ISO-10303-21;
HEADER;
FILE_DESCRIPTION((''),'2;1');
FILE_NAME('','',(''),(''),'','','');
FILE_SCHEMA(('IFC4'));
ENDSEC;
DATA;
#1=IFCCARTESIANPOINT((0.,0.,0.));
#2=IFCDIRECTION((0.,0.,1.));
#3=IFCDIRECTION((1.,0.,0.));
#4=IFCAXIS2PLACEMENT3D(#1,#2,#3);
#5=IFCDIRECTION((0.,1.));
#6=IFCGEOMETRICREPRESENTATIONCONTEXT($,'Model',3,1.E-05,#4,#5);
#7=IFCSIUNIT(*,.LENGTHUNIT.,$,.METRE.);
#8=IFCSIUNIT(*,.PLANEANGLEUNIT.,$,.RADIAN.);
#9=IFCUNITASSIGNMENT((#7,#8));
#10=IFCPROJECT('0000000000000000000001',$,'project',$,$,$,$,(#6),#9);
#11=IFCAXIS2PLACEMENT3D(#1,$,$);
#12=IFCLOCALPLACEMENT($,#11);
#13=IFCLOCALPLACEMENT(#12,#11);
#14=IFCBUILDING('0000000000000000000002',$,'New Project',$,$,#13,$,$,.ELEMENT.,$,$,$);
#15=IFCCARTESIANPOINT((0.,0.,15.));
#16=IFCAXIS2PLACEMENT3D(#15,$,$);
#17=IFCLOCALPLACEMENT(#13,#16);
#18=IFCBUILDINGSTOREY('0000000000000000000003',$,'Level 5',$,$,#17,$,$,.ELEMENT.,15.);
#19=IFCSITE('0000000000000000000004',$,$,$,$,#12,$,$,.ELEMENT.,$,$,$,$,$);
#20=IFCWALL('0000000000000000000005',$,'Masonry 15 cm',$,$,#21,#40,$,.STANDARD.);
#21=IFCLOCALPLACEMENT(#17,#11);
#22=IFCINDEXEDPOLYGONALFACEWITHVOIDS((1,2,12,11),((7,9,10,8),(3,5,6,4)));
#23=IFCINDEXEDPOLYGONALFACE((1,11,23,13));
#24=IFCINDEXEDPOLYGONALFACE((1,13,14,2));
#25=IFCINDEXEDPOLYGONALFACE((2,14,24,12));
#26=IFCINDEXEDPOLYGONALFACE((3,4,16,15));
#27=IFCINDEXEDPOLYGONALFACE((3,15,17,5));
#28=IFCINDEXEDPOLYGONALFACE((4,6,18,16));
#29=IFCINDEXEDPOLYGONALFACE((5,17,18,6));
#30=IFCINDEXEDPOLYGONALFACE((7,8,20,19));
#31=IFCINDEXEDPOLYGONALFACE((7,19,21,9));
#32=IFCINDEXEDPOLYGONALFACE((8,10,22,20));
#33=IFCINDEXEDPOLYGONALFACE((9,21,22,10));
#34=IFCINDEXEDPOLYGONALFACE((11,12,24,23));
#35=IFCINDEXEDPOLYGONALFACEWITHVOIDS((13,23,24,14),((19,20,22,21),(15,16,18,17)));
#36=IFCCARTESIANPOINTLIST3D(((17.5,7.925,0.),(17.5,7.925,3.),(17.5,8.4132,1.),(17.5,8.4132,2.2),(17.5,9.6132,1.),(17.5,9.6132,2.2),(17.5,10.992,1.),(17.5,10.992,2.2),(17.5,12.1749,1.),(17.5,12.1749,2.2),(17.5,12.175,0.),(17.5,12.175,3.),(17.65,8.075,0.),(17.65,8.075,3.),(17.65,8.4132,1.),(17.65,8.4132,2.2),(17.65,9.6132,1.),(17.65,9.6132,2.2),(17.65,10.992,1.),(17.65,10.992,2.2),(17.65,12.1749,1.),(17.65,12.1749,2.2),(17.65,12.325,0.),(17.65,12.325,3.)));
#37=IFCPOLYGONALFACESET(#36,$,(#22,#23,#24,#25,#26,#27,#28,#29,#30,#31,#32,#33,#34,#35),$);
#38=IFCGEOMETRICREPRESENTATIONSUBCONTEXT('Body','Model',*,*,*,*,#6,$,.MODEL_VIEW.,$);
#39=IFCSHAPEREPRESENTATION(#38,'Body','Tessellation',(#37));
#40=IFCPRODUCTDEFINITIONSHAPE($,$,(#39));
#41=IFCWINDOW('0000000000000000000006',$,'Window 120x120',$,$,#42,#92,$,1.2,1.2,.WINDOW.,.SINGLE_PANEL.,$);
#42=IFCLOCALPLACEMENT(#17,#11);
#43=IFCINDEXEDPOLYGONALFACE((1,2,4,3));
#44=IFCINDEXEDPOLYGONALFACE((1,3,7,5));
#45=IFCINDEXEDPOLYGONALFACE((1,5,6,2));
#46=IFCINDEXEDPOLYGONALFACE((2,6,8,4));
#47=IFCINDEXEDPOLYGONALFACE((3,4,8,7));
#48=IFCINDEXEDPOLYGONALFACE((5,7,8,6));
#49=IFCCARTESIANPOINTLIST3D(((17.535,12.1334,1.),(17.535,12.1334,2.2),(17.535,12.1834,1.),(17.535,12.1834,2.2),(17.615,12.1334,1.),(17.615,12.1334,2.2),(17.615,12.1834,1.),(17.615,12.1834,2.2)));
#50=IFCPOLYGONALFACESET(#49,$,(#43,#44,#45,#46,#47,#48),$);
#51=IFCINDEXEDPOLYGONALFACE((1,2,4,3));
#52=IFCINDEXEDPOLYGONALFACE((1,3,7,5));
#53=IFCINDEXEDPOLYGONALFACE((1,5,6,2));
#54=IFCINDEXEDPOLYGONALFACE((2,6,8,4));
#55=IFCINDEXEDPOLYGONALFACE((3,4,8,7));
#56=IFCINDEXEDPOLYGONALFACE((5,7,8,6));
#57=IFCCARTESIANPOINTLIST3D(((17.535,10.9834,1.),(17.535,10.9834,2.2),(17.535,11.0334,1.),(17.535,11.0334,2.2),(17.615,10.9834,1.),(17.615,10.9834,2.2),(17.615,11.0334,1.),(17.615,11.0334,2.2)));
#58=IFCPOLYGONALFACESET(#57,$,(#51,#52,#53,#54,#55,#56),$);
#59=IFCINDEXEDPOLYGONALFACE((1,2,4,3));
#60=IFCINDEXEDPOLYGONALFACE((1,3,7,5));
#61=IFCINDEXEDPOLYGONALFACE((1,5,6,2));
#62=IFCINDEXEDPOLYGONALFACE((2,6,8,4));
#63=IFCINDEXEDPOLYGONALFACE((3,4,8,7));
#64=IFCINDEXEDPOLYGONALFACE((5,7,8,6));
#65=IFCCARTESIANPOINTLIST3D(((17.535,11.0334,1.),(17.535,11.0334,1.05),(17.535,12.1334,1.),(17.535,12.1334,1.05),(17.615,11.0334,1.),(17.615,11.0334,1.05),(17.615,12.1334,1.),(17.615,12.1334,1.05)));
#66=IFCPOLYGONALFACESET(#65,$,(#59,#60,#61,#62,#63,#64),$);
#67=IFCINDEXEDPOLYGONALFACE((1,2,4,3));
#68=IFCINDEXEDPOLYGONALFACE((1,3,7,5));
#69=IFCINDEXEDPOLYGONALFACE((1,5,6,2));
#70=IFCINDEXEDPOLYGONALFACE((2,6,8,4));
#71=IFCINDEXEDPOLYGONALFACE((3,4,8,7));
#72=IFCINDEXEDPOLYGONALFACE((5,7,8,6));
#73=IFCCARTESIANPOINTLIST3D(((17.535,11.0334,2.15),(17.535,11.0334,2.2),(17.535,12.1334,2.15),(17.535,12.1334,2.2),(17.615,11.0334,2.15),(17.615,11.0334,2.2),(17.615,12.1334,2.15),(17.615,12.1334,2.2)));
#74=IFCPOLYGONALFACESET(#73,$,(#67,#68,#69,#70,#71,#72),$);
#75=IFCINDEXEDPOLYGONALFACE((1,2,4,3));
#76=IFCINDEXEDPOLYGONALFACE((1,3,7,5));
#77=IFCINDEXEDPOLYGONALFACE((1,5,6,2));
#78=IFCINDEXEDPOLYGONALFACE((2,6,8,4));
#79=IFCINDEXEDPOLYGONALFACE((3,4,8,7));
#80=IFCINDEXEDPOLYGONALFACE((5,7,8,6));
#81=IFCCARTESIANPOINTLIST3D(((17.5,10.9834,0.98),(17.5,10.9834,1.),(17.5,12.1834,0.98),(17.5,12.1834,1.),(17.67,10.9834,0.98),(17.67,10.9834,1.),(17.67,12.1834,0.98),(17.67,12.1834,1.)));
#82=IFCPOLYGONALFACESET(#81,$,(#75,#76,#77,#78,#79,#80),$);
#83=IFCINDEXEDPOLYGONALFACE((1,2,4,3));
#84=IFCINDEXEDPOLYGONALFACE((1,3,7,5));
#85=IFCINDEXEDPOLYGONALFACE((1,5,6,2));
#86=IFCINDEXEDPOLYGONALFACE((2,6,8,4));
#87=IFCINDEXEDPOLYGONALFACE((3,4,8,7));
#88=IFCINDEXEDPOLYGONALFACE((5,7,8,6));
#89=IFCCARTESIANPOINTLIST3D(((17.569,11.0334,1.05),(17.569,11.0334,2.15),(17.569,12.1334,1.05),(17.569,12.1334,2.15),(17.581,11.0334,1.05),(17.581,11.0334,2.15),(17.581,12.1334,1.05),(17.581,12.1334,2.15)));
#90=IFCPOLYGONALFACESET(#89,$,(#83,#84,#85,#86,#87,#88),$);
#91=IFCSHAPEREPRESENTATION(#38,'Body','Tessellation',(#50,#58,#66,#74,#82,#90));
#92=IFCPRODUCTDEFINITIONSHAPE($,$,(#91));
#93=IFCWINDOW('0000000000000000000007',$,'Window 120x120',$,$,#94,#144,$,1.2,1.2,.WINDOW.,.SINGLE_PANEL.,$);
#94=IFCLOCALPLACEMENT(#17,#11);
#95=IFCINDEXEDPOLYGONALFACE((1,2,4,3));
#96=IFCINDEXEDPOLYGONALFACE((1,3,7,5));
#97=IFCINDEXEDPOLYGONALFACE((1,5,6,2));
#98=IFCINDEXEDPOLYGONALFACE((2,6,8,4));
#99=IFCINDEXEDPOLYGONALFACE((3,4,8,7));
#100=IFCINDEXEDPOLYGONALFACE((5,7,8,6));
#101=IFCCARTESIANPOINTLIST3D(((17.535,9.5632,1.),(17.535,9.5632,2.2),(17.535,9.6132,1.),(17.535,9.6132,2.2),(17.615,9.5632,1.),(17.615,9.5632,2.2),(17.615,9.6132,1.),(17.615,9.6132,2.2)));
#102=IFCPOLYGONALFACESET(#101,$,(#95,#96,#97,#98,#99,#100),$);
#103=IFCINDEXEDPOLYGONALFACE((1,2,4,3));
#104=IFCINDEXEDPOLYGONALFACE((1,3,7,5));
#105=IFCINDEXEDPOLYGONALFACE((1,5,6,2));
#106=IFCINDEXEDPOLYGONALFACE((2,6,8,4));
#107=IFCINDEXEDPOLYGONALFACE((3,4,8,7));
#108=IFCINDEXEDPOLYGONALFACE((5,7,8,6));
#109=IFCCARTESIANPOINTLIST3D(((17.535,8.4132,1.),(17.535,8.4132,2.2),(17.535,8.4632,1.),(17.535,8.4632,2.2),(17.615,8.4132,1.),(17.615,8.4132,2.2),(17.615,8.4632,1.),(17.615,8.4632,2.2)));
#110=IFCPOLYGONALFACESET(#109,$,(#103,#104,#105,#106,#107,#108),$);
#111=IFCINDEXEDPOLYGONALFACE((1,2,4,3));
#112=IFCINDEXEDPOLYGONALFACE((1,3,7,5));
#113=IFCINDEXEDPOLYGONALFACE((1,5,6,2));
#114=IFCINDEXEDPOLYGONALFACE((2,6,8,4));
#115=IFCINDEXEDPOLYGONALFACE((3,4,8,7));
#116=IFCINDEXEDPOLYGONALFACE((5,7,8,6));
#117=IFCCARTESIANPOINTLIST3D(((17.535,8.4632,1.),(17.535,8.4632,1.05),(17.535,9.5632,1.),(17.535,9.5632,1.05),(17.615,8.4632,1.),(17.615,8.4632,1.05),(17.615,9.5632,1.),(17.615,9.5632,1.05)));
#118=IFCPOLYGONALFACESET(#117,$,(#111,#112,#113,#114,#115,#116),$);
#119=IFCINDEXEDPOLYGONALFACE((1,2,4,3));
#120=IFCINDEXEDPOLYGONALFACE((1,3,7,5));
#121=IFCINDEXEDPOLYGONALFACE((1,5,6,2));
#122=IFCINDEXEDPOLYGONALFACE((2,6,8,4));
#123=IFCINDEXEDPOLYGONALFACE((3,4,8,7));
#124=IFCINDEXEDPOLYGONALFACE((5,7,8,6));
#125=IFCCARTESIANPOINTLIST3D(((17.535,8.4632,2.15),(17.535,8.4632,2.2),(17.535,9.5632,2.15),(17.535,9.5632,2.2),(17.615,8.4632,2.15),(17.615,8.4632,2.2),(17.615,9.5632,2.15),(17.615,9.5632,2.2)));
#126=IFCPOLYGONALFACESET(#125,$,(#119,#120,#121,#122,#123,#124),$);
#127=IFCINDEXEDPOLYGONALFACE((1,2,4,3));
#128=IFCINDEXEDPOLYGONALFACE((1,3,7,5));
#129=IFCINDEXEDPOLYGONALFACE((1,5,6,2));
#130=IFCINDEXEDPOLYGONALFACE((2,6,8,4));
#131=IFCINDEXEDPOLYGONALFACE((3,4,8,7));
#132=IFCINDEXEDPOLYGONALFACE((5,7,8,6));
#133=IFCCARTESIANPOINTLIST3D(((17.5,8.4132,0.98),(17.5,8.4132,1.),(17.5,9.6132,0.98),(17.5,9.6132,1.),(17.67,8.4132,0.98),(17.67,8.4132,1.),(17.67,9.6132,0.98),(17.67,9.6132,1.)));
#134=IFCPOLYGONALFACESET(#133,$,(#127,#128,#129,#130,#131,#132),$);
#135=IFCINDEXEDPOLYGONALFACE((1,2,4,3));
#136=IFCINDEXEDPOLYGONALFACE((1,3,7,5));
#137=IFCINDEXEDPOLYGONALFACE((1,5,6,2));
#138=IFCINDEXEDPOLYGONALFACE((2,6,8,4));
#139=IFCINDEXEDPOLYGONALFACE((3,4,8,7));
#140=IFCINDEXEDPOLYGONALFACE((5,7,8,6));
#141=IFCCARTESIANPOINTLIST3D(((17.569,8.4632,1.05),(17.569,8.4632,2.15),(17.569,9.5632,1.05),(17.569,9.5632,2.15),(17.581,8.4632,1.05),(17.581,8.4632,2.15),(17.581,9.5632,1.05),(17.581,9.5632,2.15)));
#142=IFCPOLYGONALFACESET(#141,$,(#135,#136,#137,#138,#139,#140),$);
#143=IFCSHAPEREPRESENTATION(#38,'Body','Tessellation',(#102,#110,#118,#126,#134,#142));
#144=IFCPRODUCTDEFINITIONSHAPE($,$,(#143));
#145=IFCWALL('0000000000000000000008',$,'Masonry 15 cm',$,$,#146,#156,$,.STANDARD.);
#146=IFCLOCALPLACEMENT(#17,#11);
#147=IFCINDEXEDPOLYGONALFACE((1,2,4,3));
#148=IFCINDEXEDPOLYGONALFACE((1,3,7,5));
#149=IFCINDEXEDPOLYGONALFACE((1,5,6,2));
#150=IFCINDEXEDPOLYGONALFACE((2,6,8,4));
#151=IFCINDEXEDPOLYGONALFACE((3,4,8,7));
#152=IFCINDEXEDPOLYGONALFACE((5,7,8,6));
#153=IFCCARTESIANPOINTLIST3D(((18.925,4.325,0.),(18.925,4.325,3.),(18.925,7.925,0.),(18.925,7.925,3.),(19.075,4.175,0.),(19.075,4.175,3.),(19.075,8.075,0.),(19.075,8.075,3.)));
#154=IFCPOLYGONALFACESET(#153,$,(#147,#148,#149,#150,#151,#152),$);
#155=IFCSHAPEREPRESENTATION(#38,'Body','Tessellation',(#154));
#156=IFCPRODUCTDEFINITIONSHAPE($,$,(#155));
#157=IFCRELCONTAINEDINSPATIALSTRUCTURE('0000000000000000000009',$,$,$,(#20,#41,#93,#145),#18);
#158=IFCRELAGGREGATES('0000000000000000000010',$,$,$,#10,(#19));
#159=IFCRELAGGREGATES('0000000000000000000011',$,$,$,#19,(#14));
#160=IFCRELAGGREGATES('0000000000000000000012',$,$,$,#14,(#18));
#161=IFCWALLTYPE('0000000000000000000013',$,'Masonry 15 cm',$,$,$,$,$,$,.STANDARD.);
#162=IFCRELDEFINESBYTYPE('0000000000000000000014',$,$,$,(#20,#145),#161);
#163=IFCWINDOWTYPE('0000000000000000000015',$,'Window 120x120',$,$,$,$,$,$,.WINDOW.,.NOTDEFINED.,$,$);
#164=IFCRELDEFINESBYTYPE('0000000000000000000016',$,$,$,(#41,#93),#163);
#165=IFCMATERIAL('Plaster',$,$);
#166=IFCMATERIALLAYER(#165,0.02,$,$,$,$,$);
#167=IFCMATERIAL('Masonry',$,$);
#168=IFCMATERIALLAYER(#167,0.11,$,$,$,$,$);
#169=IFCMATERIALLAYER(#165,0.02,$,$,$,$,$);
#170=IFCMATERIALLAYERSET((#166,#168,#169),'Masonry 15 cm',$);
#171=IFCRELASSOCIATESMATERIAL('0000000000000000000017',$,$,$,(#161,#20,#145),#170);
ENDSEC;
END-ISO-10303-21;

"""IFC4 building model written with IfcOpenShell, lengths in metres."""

from ifc_helpers import new_model, si_unit, direction, frame, frame_2d, origin, origin_with_axes, place, context, subcontext, project, spatial, polyline, rectangle, outline, extrude, material, layer, layer_set, layer_usage, type_object, element, fill, save


model = new_model("IFC4")

# Units and contexts
model_context = context("Model", 3, precision=1e-05, world=origin_with_axes(), true_north=direction((0.0, 1.0)))
body_context = subcontext(model_context, "Body", "Model", "MODEL_VIEW")
ifc_project = project(units=[si_unit("LENGTHUNIT", "METRE"), si_unit("PLANEANGLEUNIT", "RADIAN")], contexts=[model_context])

# Site, building, storey
site_placement = place(None, origin())
site = spatial("IfcSite", under=ifc_project, at=site_placement, CompositionType="ELEMENT")
building_placement = place(site_placement, origin())
building = spatial("IfcBuilding", under=site, at=building_placement, Name="New Project", CompositionType="ELEMENT")
storey_placement = place(building_placement, frame((0.0, 0.0, 15.0)))
storey = spatial("IfcBuildingStorey", under=building, at=storey_placement, Name="Level 5", CompositionType="ELEMENT", Elevation=15.0)

# Shared definitions
ifc_material_1 = material(Name="Plaster")
ifc_layer_1 = layer(ifc_material_1, 0.02)
ifc_material_2 = material(Name="Masonry")
ifc_layer_2 = layer(ifc_material_2, 0.11)
ifc_layer_3 = layer(ifc_material_1, 0.02)
ifc_layer_set_1 = layer_set([ifc_layer_1, ifc_layer_2, ifc_layer_3], Name="Masonry 15 cm")
ifc_layer_usage_1 = layer_usage(ifc_layer_set_1, "AXIS2", "NEGATIVE", 0.075)
wall_type_1 = type_object("IfcWallType", Name="Masonry 15 cm", PredefinedType="STANDARD", material=ifc_layer_set_1)
window_type = type_object("IfcWindowType", Name="Window 120x120", PartitioningType="NOTDEFINED", PredefinedType="WINDOW")

# Wall, openings, windows
wall_1_placement = place(storey_placement, frame((17.575, 12.25, 0.0), z_axis=(0.0, 0.0, 1.0), x_axis=(0.0, -1.0, 0.0)))
wall_1 = element("IfcWall", 1, at=wall_1_placement, inside=storey, type_object=wall_type_1, material=ifc_layer_usage_1, Name="Masonry 15 cm", PredefinedType="STANDARD", context=body_context, shape_type="SweptSolid", body=[
    extrude(outline(polyline([(0.075, -0.075), (4.325, -0.075), (4.175, 0.075), (-0.075, 0.075), (0.075, -0.075)])), origin(), (0.0, 0.0, 1.0), 3.0),
])
opening_1_placement = place(wall_1_placement, frame((0.0751, 0.0, 1.0)))
opening_1 = element("IfcOpeningElement", 2, at=opening_1_placement, cuts=wall_1, PredefinedType="OPENING", context=body_context, shape_type="SweptSolid", body=[
    extrude(rectangle(XDim=1.1829, YDim=0.25, at=frame_2d((0.5915, 0.0))), origin(), (0.0, 0.0, 1.0), 1.2),
])
opening_2_placement = place(wall_1_placement, frame((2.6368, 0.0, 1.0)))
opening_2 = element("IfcOpeningElement", 3, at=opening_2_placement, cuts=wall_1, PredefinedType="OPENING", context=body_context, shape_type="SweptSolid", body=[
    extrude(rectangle(XDim=1.2, YDim=0.25, at=frame_2d((0.6, 0.0))), origin(), (0.0, 0.0, 1.0), 1.2),
])
window_1_placement = place(opening_1_placement, origin())
window_1 = element("IfcWindow", 4, at=window_1_placement, inside=storey, type_object=window_type, Name="Window 120x120", OverallHeight=1.2, OverallWidth=1.2, PartitioningType="SINGLE_PANEL", PredefinedType="WINDOW", context=body_context, shape_type="SweptSolid", body=[
    extrude(outline(polyline([(-0.0085, -0.04), (0.0415, -0.04), (0.0415, 0.04), (-0.0085, 0.04), (-0.0085, -0.04)])), origin(), (0.0, 0.0, 1.0), 1.2),
    extrude(outline(polyline([(1.1415, -0.04), (1.1915, -0.04), (1.1915, 0.04), (1.1415, 0.04), (1.1415, -0.04)])), origin(), (0.0, 0.0, 1.0), 1.2),
    extrude(outline(polyline([(0.0415, -0.04), (1.1415, -0.04), (1.1415, 0.04), (0.0415, 0.04), (0.0415, -0.04)])), origin(), (0.0, 0.0, 1.0), 0.05),
    extrude(outline(polyline([(0.0415, -0.04), (1.1415, -0.04), (1.1415, 0.04), (0.0415, 0.04), (0.0415, -0.04)])), frame((0.0, 0.0, 1.15)), (0.0, 0.0, 1.0), 0.05),
    extrude(outline(polyline([(-0.0085, -0.075), (1.1915, -0.075), (1.1915, 0.095), (-0.0085, 0.095), (-0.0085, -0.075)])), frame((0.0, 0.0, -0.02)), (0.0, 0.0, 1.0), 0.02),
    extrude(outline(polyline([(0.0415, -0.006), (1.1415, -0.006), (1.1415, 0.006), (0.0415, 0.006), (0.0415, -0.006)])), frame((0.0, 0.0, 0.05)), (0.0, 0.0, 1.0), 1.1),
])
fill(opening_1, window_1)
window_2_placement = place(opening_2_placement, origin())
window_2 = element("IfcWindow", 5, at=window_2_placement, inside=storey, type_object=window_type, Name="Window 120x120", OverallHeight=1.2, OverallWidth=1.2, PartitioningType="SINGLE_PANEL", PredefinedType="WINDOW", context=body_context, shape_type="SweptSolid", body=[
    extrude(outline(polyline([(0.0, -0.04), (0.05, -0.04), (0.05, 0.04), (0.0, 0.04), (0.0, -0.04)])), origin(), (0.0, 0.0, 1.0), 1.2),
    extrude(outline(polyline([(1.15, -0.04), (1.2, -0.04), (1.2, 0.04), (1.15, 0.04), (1.15, -0.04)])), origin(), (0.0, 0.0, 1.0), 1.2),
    extrude(outline(polyline([(0.05, -0.04), (1.15, -0.04), (1.15, 0.04), (0.05, 0.04), (0.05, -0.04)])), origin(), (0.0, 0.0, 1.0), 0.05),
    extrude(outline(polyline([(0.05, -0.04), (1.15, -0.04), (1.15, 0.04), (0.05, 0.04), (0.05, -0.04)])), frame((0.0, 0.0, 1.15)), (0.0, 0.0, 1.0), 0.05),
    extrude(outline(polyline([(0.0, -0.075), (1.2, -0.075), (1.2, 0.095), (0.0, 0.095), (0.0, -0.075)])), frame((0.0, 0.0, -0.02)), (0.0, 0.0, 1.0), 0.02),
    extrude(outline(polyline([(0.05, -0.006), (1.15, -0.006), (1.15, 0.006), (0.05, 0.006), (0.05, -0.006)])), frame((0.0, 0.0, 0.05)), (0.0, 0.0, 1.0), 1.1),
])
fill(opening_2, window_2)

# Wall
wall_2_placement = place(storey_placement, frame((19.0, 8.0, 0.0), z_axis=(0.0, 0.0, 1.0), x_axis=(0.0, -1.0, 0.0)))
element("IfcWall", 6, at=wall_2_placement, inside=storey, type_object=wall_type_1, material=ifc_layer_usage_1, Name="Masonry 15 cm", PredefinedType="STANDARD", context=body_context, shape_type="SweptSolid", body=[
    extrude(outline(polyline([(0.075, -0.075), (3.675, -0.075), (3.825, 0.075), (-0.075, 0.075), (0.075, -0.075)])), origin(), (0.0, 0.0, 1.0), 3.0),
])

save(model, "model.ifc")
